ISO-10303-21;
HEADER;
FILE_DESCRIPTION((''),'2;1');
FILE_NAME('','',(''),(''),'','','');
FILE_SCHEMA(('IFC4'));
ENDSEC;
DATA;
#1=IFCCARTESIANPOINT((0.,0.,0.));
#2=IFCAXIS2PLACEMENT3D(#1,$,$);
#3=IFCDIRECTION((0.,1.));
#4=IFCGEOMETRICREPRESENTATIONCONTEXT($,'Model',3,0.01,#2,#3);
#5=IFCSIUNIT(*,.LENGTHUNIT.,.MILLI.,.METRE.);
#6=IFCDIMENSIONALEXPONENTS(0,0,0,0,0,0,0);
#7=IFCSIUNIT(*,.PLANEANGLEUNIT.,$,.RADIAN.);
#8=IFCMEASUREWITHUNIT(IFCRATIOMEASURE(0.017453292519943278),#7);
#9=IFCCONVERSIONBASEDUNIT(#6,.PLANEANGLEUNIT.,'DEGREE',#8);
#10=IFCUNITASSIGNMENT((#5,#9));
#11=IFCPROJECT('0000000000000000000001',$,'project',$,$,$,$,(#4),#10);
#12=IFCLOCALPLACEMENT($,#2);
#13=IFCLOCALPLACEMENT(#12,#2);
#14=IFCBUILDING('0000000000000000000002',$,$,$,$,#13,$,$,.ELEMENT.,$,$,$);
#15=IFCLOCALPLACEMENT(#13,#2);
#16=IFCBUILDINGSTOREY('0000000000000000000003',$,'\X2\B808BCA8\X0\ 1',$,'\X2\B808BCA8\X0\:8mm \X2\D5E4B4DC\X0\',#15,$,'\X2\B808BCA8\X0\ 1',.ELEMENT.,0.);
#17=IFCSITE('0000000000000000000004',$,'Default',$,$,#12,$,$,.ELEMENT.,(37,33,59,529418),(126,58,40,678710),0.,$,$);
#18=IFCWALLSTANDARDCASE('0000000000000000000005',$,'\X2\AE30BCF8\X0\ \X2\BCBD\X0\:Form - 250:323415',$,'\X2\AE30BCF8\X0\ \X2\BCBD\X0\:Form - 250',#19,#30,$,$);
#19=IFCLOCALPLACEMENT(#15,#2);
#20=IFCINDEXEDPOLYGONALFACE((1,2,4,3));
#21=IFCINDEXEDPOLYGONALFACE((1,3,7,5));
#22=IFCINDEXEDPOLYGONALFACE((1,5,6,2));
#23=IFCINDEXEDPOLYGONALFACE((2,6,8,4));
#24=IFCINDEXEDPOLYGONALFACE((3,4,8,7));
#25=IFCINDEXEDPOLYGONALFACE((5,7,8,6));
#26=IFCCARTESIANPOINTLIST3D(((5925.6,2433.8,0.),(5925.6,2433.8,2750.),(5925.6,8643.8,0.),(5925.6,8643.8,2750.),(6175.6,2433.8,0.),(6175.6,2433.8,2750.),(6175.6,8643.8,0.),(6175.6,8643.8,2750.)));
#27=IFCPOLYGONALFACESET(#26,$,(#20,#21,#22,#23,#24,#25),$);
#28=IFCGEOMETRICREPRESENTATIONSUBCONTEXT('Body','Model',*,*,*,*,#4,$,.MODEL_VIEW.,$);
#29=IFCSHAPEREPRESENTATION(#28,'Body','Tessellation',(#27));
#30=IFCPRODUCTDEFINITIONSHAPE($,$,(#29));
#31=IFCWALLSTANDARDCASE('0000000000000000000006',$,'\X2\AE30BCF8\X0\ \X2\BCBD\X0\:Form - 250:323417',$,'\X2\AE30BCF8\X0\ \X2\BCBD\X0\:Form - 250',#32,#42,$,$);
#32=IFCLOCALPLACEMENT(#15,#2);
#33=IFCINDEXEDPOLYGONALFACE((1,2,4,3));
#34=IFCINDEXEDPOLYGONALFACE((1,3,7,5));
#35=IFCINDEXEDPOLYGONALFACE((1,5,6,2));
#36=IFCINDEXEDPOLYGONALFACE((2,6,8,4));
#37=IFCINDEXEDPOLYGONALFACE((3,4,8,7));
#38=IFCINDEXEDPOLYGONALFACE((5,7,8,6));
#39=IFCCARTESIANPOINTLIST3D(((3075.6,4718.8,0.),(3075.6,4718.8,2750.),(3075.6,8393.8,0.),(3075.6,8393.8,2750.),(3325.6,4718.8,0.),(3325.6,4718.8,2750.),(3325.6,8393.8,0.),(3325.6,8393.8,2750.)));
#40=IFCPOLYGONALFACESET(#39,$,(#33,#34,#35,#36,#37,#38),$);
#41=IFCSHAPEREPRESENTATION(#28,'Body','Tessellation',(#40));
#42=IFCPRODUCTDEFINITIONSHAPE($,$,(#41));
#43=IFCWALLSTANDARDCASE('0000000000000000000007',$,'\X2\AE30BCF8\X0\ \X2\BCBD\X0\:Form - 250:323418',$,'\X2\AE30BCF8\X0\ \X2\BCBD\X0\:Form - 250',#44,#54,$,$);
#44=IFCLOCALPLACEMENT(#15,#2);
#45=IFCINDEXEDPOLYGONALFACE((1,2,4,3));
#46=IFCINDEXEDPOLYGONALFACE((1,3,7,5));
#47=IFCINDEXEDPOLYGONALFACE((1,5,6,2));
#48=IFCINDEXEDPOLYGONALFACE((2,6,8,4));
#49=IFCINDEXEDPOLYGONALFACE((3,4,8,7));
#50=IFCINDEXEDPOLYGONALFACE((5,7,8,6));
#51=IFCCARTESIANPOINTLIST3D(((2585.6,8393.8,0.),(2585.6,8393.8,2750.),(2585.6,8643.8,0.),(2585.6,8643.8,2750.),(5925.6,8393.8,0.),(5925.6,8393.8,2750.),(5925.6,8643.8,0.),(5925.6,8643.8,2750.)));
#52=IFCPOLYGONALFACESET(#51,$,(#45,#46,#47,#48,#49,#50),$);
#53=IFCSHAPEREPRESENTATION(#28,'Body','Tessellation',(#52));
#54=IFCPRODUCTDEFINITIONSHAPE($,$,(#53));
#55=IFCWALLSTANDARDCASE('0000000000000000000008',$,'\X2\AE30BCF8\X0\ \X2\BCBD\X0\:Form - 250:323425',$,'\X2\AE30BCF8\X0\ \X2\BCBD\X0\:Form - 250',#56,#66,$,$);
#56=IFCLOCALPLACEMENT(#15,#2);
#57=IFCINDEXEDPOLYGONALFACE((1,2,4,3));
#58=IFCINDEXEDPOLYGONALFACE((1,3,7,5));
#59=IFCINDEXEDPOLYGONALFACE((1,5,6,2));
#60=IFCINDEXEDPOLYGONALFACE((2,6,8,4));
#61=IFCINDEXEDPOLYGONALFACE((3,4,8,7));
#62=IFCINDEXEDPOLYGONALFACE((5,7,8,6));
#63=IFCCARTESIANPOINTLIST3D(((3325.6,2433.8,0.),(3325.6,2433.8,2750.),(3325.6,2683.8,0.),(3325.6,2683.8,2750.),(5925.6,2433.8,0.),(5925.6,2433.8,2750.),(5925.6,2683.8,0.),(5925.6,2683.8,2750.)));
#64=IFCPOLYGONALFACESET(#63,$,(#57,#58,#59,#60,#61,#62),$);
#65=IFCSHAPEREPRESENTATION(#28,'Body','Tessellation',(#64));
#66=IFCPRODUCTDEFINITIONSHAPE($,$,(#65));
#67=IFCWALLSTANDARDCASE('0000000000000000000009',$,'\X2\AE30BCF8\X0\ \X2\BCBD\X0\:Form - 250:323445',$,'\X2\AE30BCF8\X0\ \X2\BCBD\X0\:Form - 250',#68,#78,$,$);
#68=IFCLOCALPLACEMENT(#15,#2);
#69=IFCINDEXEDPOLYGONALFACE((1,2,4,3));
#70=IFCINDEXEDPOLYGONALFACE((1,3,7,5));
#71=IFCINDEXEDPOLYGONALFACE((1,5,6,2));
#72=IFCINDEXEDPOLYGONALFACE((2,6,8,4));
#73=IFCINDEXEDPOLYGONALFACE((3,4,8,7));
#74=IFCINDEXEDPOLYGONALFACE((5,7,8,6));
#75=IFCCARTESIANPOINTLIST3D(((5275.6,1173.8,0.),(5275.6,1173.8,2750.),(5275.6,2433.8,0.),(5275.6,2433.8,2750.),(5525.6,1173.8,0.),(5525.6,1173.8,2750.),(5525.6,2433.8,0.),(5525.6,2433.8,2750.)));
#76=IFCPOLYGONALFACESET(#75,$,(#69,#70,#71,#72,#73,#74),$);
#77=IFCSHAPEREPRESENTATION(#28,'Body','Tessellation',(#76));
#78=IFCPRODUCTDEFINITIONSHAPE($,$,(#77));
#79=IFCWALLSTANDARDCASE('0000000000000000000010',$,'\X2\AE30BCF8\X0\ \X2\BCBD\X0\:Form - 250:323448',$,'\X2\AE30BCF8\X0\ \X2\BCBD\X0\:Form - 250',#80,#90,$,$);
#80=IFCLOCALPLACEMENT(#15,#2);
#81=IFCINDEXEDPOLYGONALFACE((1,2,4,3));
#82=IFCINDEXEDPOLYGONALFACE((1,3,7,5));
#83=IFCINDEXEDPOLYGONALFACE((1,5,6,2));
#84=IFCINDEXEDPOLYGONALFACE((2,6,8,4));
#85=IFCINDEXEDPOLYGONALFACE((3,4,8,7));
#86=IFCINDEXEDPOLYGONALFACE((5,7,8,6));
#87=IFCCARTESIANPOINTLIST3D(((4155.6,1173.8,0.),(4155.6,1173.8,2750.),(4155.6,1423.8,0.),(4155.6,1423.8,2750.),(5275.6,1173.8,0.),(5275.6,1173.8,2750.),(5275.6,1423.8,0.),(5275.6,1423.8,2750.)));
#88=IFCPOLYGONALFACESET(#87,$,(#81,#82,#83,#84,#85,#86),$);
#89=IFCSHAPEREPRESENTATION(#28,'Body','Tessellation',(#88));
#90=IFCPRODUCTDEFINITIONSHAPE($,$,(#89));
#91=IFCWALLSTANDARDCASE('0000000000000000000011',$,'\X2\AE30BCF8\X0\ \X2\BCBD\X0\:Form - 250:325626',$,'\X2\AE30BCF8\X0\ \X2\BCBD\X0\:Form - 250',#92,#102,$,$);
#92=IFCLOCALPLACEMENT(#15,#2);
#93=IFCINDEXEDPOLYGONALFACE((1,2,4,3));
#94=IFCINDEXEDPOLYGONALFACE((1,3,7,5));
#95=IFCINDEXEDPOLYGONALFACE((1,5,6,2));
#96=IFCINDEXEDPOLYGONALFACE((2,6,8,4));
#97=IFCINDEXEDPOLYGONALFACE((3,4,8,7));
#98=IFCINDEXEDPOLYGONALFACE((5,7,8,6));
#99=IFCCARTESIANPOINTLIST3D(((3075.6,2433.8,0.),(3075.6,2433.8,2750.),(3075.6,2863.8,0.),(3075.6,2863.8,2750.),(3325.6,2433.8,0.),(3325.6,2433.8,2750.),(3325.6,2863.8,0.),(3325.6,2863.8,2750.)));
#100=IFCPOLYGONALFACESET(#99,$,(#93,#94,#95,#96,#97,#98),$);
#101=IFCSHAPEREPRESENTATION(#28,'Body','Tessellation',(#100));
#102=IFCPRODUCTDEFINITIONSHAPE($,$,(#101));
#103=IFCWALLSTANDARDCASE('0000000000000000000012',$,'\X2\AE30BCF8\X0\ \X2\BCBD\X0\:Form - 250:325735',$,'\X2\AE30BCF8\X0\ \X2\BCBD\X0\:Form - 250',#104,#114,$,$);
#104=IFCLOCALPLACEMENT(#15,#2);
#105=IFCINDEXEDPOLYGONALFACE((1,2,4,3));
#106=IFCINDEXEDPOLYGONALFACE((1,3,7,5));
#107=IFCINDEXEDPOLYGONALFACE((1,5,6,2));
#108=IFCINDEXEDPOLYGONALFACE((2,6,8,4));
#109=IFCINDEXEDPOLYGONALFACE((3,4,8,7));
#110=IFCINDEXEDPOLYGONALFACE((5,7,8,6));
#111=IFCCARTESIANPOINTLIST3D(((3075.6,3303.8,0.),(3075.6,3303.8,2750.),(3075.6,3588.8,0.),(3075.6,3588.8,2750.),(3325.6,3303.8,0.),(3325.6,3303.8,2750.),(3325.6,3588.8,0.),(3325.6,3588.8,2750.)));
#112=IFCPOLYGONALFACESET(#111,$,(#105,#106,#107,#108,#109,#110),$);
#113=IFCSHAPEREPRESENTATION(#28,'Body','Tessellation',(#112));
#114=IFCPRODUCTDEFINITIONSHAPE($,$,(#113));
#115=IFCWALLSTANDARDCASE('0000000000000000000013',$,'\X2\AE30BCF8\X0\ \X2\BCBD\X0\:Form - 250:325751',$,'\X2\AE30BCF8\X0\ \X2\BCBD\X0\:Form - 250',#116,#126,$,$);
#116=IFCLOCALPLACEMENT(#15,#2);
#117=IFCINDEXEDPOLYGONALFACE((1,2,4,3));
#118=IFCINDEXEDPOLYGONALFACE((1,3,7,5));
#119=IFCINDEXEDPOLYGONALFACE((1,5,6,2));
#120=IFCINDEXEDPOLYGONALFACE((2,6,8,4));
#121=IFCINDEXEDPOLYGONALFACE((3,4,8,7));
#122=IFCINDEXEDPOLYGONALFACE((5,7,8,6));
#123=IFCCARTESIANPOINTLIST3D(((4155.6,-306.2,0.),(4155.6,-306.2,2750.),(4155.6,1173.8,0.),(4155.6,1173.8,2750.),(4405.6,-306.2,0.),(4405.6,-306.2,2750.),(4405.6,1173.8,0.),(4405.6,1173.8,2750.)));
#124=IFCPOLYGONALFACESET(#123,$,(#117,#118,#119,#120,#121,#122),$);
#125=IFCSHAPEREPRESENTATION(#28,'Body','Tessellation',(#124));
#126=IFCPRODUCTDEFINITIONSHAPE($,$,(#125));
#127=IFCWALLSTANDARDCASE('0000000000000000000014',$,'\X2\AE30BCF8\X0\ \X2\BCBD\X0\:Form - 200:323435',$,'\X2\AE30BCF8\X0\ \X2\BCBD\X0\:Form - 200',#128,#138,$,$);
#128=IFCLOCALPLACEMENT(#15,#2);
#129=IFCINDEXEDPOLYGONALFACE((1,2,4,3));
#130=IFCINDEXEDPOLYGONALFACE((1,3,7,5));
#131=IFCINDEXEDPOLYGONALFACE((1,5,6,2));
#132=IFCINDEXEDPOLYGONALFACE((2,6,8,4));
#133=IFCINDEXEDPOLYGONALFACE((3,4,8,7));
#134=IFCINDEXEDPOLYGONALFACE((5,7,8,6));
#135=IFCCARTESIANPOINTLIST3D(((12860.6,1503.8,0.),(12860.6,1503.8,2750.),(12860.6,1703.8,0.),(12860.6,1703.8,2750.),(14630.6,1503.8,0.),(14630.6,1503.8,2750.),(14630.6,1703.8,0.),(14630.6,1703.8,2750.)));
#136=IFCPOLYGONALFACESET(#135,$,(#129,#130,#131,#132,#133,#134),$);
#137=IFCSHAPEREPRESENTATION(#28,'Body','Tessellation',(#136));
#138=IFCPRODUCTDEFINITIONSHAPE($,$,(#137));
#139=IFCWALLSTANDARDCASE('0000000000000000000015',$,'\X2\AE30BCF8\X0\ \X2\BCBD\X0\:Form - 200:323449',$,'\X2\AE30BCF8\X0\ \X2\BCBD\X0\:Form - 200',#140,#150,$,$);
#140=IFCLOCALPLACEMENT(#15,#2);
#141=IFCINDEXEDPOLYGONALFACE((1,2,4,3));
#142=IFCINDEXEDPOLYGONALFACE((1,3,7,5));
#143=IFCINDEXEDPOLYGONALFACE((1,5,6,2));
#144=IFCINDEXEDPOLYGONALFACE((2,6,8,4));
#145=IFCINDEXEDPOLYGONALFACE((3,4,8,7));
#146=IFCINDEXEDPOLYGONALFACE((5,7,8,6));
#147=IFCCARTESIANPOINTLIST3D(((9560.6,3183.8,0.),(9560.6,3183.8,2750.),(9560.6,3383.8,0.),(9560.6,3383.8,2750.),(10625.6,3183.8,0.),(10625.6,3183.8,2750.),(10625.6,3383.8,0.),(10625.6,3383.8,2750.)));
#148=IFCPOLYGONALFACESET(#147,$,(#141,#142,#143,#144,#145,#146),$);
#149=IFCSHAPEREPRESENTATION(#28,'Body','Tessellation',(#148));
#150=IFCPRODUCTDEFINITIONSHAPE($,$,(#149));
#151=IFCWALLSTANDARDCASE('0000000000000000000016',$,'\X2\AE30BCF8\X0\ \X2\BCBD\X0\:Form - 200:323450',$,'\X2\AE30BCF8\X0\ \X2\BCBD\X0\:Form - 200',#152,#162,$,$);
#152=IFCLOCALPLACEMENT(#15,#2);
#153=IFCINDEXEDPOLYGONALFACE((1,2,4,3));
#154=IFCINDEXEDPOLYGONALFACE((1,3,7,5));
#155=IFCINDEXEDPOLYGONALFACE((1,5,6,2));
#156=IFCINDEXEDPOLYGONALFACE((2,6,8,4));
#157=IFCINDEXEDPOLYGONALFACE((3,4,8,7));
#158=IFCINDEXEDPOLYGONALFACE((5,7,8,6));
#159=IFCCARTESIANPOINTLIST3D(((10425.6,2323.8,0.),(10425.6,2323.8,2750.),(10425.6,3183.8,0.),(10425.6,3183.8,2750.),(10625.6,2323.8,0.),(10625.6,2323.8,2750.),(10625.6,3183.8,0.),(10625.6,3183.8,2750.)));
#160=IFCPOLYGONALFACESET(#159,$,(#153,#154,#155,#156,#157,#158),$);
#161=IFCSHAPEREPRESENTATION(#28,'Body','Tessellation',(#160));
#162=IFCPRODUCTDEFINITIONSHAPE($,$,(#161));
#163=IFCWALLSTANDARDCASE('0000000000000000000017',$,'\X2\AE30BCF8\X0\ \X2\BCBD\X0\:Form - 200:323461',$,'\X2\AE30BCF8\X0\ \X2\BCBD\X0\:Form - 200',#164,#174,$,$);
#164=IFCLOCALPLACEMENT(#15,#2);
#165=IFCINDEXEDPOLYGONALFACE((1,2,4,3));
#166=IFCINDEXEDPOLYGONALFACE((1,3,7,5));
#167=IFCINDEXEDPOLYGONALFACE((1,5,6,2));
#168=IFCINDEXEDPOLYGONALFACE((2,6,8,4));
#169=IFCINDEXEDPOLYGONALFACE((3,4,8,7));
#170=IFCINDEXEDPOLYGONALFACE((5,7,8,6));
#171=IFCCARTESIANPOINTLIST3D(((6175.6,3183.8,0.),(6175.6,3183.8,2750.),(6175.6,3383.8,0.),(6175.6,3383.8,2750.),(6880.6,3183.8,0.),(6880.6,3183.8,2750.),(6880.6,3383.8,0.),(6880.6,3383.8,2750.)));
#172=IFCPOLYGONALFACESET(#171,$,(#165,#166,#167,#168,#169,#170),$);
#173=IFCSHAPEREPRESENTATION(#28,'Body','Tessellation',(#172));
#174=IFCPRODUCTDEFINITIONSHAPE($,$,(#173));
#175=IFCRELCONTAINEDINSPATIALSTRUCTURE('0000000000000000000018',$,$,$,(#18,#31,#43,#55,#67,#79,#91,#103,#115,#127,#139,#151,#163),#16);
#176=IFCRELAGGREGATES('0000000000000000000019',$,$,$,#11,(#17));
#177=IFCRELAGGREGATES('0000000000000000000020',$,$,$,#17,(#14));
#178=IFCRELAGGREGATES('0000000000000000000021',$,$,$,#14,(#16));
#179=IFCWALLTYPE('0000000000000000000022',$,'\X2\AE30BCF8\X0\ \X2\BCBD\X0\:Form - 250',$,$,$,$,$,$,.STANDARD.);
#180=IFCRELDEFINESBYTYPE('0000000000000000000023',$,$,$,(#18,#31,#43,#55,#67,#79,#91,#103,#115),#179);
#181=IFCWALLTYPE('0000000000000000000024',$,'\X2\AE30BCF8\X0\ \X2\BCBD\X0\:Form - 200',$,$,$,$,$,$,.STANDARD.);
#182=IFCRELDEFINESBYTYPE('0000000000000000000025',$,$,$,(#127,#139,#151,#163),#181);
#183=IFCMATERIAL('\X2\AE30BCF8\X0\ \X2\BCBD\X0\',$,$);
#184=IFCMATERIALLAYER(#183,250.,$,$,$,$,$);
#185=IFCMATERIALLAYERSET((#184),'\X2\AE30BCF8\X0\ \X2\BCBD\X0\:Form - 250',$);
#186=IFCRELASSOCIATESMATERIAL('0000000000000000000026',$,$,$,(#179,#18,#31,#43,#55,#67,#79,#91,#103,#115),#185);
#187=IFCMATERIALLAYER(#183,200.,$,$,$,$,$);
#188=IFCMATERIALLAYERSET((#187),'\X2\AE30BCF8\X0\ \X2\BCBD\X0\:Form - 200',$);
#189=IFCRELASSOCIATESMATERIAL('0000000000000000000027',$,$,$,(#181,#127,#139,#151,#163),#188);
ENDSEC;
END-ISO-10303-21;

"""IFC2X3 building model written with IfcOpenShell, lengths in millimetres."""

from ifc_helpers import new_model, entity, si_unit, converted_unit, direction, frame, frame_2d, origin, place, context, subcontext, project, spatial, rectangle, extrude, material, layer, layer_set, layer_usage, type_object, element, save


model = new_model("IFC2X3")

# Units and contexts
model_context = context("Model", 3, precision=0.01, world=origin(), true_north=direction((0.0, 1.0)))
body_context = subcontext(model_context, "Body", "Model", "MODEL_VIEW")
ifc_project = project(units=[si_unit("LENGTHUNIT", "METRE", prefix="MILLI"), converted_unit("PLANEANGLEUNIT", "DEGREE", entity("IfcRatioMeasure", 0.017453292519943278), si_unit("PLANEANGLEUNIT", "RADIAN"), dimensions=[0, 0, 0, 0, 0, 0, 0])], contexts=[model_context])

# Site, building, storey
site_placement = place(None, origin())
site = spatial("IfcSite", under=ifc_project, at=site_placement, Name="Default", CompositionType="ELEMENT", RefLatitude=(37, 33, 59, 529418), RefLongitude=(126, 58, 40, 678710), RefElevation=0.0)
building_placement = place(site_placement, origin())
building = spatial("IfcBuilding", under=site, at=building_placement, CompositionType="ELEMENT")
storey_placement = place(building_placement, origin())
storey = spatial("IfcBuildingStorey", under=building, at=storey_placement, Name="레벨 1", ObjectType="레벨:8mm 헤드", LongName="레벨 1", CompositionType="ELEMENT", Elevation=0.0)

# Walls
ifc_material_1 = material(Name="기본 벽")
ifc_layer_1 = layer(ifc_material_1, 250.0)
ifc_layer_set_1 = layer_set([ifc_layer_1], Name="기본 벽:Form - 250")
ifc_layer_usage_1 = layer_usage(ifc_layer_set_1, "AXIS2", "POSITIVE", -125.0)
wall_type_1 = type_object("IfcWallType", Name="기본 벽:Form - 250", PredefinedType="STANDARD", material=ifc_layer_set_1)
wall_1_placement = place(storey_placement, frame((6050.6, 8643.8, 0.0), z_axis=(0.0, 0.0, 1.0), x_axis=(0.0, -1.0, 0.0)))
element("IfcWallStandardCase", 1, at=wall_1_placement, inside=storey, type_object=wall_type_1, material=ifc_layer_usage_1, Name="기본 벽:Form - 250:323415", ObjectType="기본 벽:Form - 250", context=body_context, shape_type="SweptSolid", body=[
    extrude(rectangle(XDim=6210.0, YDim=250.0, at=frame_2d((3105.0, 0.0), x_axis=(-1.0, 0.0))), origin(), (0.0, 0.0, 1.0), 2750.0),
])
ifc_layer_usage_2 = layer_usage(ifc_layer_set_1, "AXIS2", "POSITIVE", -125.0)
wall_2_placement = place(storey_placement, frame((3200.6, 8393.8, 0.0), z_axis=(0.0, 0.0, 1.0), x_axis=(0.0, -1.0, 0.0)))
element("IfcWallStandardCase", 2, at=wall_2_placement, inside=storey, type_object=wall_type_1, material=ifc_layer_usage_2, Name="기본 벽:Form - 250:323417", ObjectType="기본 벽:Form - 250", context=body_context, shape_type="SweptSolid", body=[
    extrude(rectangle(XDim=3675.0, YDim=250.0, at=frame_2d((1837.5, 0.0), x_axis=(-1.0, 0.0))), origin(), (0.0, 0.0, 1.0), 2750.0),
])
ifc_layer_usage_3 = layer_usage(ifc_layer_set_1, "AXIS2", "POSITIVE", -125.0)
wall_3_placement = place(storey_placement, frame((2585.6, 8518.8, 0.0)))
element("IfcWallStandardCase", 3, at=wall_3_placement, inside=storey, type_object=wall_type_1, material=ifc_layer_usage_3, Name="기본 벽:Form - 250:323418", ObjectType="기본 벽:Form - 250", context=body_context, shape_type="SweptSolid", body=[
    extrude(rectangle(XDim=3340.0, YDim=250.0, at=frame_2d((1670.0, 0.0), x_axis=(-1.0, 0.0))), origin(), (0.0, 0.0, 1.0), 2750.0),
])
ifc_layer_usage_4 = layer_usage(ifc_layer_set_1, "AXIS2", "POSITIVE", -125.0)
wall_4_placement = place(storey_placement, frame((5925.6, 2558.8, 0.0), z_axis=(0.0, 0.0, 1.0), x_axis=(-1.0, 0.0, 0.0)))
element("IfcWallStandardCase", 4, at=wall_4_placement, inside=storey, type_object=wall_type_1, material=ifc_layer_usage_4, Name="기본 벽:Form - 250:323425", ObjectType="기본 벽:Form - 250", context=body_context, shape_type="SweptSolid", body=[
    extrude(rectangle(XDim=2600.0, YDim=250.0, at=frame_2d((1300.0, 0.0), x_axis=(-1.0, 0.0))), origin(), (0.0, 0.0, 1.0), 2750.0),
])
ifc_layer_usage_5 = layer_usage(ifc_layer_set_1, "AXIS2", "POSITIVE", -125.0)
wall_5_placement = place(storey_placement, frame((5400.6, 2433.8, 0.0), z_axis=(0.0, 0.0, 1.0), x_axis=(0.0, -1.0, 0.0)))
element("IfcWallStandardCase", 5, at=wall_5_placement, inside=storey, type_object=wall_type_1, material=ifc_layer_usage_5, Name="기본 벽:Form - 250:323445", ObjectType="기본 벽:Form - 250", context=body_context, shape_type="SweptSolid", body=[
    extrude(rectangle(XDim=1260.0, YDim=250.0, at=frame_2d((630.0, 0.0), x_axis=(-1.0, 0.0))), origin(), (0.0, 0.0, 1.0), 2750.0),
])
ifc_layer_usage_6 = layer_usage(ifc_layer_set_1, "AXIS2", "POSITIVE", -125.0)
wall_6_placement = place(storey_placement, frame((5275.6, 1298.8, 0.0), z_axis=(0.0, 0.0, 1.0), x_axis=(-1.0, 0.0, 0.0)))
element("IfcWallStandardCase", 6, at=wall_6_placement, inside=storey, type_object=wall_type_1, material=ifc_layer_usage_6, Name="기본 벽:Form - 250:323448", ObjectType="기본 벽:Form - 250", context=body_context, shape_type="SweptSolid", body=[
    extrude(rectangle(XDim=1120.0, YDim=250.0, at=frame_2d((560.0, 0.0), x_axis=(-1.0, 0.0))), origin(), (0.0, 0.0, 1.0), 2750.0),
])
ifc_layer_usage_7 = layer_usage(ifc_layer_set_1, "AXIS2", "POSITIVE", -125.0)
wall_7_placement = place(storey_placement, frame((3200.6, 2863.8, 0.0), z_axis=(0.0, 0.0, 1.0), x_axis=(0.0, -1.0, 0.0)))
element("IfcWallStandardCase", 7, at=wall_7_placement, inside=storey, type_object=wall_type_1, material=ifc_layer_usage_7, Name="기본 벽:Form - 250:325626", ObjectType="기본 벽:Form - 250", context=body_context, shape_type="SweptSolid", body=[
    extrude(rectangle(XDim=430.0, YDim=250.0, at=frame_2d((215.0, 0.0), x_axis=(-1.0, 0.0))), origin(), (0.0, 0.0, 1.0), 2750.0),
])
ifc_layer_usage_8 = layer_usage(ifc_layer_set_1, "AXIS2", "POSITIVE", -125.0)
wall_8_placement = place(storey_placement, frame((3200.6, 3588.8, 0.0), z_axis=(0.0, 0.0, 1.0), x_axis=(0.0, -1.0, 0.0)))
element("IfcWallStandardCase", 8, at=wall_8_placement, inside=storey, type_object=wall_type_1, material=ifc_layer_usage_8, Name="기본 벽:Form - 250:325735", ObjectType="기본 벽:Form - 250", context=body_context, shape_type="SweptSolid", body=[
    extrude(rectangle(XDim=285.0, YDim=250.0, at=frame_2d((142.5, 0.0), x_axis=(-1.0, 0.0))), origin(), (0.0, 0.0, 1.0), 2750.0),
])
ifc_layer_usage_9 = layer_usage(ifc_layer_set_1, "AXIS2", "POSITIVE", -125.0)
wall_9_placement = place(storey_placement, frame((4280.6, 1173.8, 0.0), z_axis=(0.0, 0.0, 1.0), x_axis=(0.0, -1.0, 0.0)))
element("IfcWallStandardCase", 9, at=wall_9_placement, inside=storey, type_object=wall_type_1, material=ifc_layer_usage_9, Name="기본 벽:Form - 250:325751", ObjectType="기본 벽:Form - 250", context=body_context, shape_type="SweptSolid", body=[
    extrude(rectangle(XDim=1480.0, YDim=250.0, at=frame_2d((740.0, 0.0), x_axis=(-1.0, 0.0))), origin(), (0.0, 0.0, 1.0), 2750.0),
])
ifc_layer_2 = layer(ifc_material_1, 200.0)
ifc_layer_set_2 = layer_set([ifc_layer_2], Name="기본 벽:Form - 200")
ifc_layer_usage_10 = layer_usage(ifc_layer_set_2, "AXIS2", "POSITIVE", -100.0)
wall_type_2 = type_object("IfcWallType", Name="기본 벽:Form - 200", PredefinedType="STANDARD", material=ifc_layer_set_2)
wall_10_placement = place(storey_placement, frame((14630.6, 1603.8, 0.0), z_axis=(0.0, 0.0, 1.0), x_axis=(-1.0, 0.0, 0.0)))
element("IfcWallStandardCase", 10, at=wall_10_placement, inside=storey, type_object=wall_type_2, material=ifc_layer_usage_10, Name="기본 벽:Form - 200:323435", ObjectType="기본 벽:Form - 200", context=body_context, shape_type="SweptSolid", body=[
    extrude(rectangle(XDim=1770.0, YDim=200.0, at=frame_2d((885.0, 0.0), x_axis=(-1.0, 0.0))), origin(), (0.0, 0.0, 1.0), 2750.0),
])
ifc_layer_usage_11 = layer_usage(ifc_layer_set_2, "AXIS2", "POSITIVE", -100.0)
wall_11_placement = place(storey_placement, frame((9560.6, 3283.8, 0.0)))
element("IfcWallStandardCase", 11, at=wall_11_placement, inside=storey, type_object=wall_type_2, material=ifc_layer_usage_11, Name="기본 벽:Form - 200:323449", ObjectType="기본 벽:Form - 200", context=body_context, shape_type="SweptSolid", body=[
    extrude(rectangle(XDim=1065.0, YDim=200.0, at=frame_2d((532.5, 0.0), x_axis=(-1.0, 0.0))), origin(), (0.0, 0.0, 1.0), 2750.0),
])
ifc_layer_usage_12 = layer_usage(ifc_layer_set_2, "AXIS2", "POSITIVE", -100.0)
wall_12_placement = place(storey_placement, frame((10525.6, 3183.8, 0.0), z_axis=(0.0, 0.0, 1.0), x_axis=(0.0, -1.0, 0.0)))
element("IfcWallStandardCase", 12, at=wall_12_placement, inside=storey, type_object=wall_type_2, material=ifc_layer_usage_12, Name="기본 벽:Form - 200:323450", ObjectType="기본 벽:Form - 200", context=body_context, shape_type="SweptSolid", body=[
    extrude(rectangle(XDim=860.0, YDim=200.0, at=frame_2d((430.0, 0.0), x_axis=(-1.0, 0.0))), origin(), (0.0, 0.0, 1.0), 2750.0),
])
ifc_layer_usage_13 = layer_usage(ifc_layer_set_2, "AXIS2", "POSITIVE", -100.0)
wall_13_placement = place(storey_placement, frame((6175.6, 3283.8, 0.0)))
element("IfcWallStandardCase", 13, at=wall_13_placement, inside=storey, type_object=wall_type_2, material=ifc_layer_usage_13, Name="기본 벽:Form - 200:323461", ObjectType="기본 벽:Form - 200", context=body_context, shape_type="SweptSolid", body=[
    extrude(rectangle(XDim=705.0, YDim=200.0, at=frame_2d((352.5, 0.0), x_axis=(-1.0, 0.0))), origin(), (0.0, 0.0, 1.0), 2750.0),
])

save(model, "model.ifc")
